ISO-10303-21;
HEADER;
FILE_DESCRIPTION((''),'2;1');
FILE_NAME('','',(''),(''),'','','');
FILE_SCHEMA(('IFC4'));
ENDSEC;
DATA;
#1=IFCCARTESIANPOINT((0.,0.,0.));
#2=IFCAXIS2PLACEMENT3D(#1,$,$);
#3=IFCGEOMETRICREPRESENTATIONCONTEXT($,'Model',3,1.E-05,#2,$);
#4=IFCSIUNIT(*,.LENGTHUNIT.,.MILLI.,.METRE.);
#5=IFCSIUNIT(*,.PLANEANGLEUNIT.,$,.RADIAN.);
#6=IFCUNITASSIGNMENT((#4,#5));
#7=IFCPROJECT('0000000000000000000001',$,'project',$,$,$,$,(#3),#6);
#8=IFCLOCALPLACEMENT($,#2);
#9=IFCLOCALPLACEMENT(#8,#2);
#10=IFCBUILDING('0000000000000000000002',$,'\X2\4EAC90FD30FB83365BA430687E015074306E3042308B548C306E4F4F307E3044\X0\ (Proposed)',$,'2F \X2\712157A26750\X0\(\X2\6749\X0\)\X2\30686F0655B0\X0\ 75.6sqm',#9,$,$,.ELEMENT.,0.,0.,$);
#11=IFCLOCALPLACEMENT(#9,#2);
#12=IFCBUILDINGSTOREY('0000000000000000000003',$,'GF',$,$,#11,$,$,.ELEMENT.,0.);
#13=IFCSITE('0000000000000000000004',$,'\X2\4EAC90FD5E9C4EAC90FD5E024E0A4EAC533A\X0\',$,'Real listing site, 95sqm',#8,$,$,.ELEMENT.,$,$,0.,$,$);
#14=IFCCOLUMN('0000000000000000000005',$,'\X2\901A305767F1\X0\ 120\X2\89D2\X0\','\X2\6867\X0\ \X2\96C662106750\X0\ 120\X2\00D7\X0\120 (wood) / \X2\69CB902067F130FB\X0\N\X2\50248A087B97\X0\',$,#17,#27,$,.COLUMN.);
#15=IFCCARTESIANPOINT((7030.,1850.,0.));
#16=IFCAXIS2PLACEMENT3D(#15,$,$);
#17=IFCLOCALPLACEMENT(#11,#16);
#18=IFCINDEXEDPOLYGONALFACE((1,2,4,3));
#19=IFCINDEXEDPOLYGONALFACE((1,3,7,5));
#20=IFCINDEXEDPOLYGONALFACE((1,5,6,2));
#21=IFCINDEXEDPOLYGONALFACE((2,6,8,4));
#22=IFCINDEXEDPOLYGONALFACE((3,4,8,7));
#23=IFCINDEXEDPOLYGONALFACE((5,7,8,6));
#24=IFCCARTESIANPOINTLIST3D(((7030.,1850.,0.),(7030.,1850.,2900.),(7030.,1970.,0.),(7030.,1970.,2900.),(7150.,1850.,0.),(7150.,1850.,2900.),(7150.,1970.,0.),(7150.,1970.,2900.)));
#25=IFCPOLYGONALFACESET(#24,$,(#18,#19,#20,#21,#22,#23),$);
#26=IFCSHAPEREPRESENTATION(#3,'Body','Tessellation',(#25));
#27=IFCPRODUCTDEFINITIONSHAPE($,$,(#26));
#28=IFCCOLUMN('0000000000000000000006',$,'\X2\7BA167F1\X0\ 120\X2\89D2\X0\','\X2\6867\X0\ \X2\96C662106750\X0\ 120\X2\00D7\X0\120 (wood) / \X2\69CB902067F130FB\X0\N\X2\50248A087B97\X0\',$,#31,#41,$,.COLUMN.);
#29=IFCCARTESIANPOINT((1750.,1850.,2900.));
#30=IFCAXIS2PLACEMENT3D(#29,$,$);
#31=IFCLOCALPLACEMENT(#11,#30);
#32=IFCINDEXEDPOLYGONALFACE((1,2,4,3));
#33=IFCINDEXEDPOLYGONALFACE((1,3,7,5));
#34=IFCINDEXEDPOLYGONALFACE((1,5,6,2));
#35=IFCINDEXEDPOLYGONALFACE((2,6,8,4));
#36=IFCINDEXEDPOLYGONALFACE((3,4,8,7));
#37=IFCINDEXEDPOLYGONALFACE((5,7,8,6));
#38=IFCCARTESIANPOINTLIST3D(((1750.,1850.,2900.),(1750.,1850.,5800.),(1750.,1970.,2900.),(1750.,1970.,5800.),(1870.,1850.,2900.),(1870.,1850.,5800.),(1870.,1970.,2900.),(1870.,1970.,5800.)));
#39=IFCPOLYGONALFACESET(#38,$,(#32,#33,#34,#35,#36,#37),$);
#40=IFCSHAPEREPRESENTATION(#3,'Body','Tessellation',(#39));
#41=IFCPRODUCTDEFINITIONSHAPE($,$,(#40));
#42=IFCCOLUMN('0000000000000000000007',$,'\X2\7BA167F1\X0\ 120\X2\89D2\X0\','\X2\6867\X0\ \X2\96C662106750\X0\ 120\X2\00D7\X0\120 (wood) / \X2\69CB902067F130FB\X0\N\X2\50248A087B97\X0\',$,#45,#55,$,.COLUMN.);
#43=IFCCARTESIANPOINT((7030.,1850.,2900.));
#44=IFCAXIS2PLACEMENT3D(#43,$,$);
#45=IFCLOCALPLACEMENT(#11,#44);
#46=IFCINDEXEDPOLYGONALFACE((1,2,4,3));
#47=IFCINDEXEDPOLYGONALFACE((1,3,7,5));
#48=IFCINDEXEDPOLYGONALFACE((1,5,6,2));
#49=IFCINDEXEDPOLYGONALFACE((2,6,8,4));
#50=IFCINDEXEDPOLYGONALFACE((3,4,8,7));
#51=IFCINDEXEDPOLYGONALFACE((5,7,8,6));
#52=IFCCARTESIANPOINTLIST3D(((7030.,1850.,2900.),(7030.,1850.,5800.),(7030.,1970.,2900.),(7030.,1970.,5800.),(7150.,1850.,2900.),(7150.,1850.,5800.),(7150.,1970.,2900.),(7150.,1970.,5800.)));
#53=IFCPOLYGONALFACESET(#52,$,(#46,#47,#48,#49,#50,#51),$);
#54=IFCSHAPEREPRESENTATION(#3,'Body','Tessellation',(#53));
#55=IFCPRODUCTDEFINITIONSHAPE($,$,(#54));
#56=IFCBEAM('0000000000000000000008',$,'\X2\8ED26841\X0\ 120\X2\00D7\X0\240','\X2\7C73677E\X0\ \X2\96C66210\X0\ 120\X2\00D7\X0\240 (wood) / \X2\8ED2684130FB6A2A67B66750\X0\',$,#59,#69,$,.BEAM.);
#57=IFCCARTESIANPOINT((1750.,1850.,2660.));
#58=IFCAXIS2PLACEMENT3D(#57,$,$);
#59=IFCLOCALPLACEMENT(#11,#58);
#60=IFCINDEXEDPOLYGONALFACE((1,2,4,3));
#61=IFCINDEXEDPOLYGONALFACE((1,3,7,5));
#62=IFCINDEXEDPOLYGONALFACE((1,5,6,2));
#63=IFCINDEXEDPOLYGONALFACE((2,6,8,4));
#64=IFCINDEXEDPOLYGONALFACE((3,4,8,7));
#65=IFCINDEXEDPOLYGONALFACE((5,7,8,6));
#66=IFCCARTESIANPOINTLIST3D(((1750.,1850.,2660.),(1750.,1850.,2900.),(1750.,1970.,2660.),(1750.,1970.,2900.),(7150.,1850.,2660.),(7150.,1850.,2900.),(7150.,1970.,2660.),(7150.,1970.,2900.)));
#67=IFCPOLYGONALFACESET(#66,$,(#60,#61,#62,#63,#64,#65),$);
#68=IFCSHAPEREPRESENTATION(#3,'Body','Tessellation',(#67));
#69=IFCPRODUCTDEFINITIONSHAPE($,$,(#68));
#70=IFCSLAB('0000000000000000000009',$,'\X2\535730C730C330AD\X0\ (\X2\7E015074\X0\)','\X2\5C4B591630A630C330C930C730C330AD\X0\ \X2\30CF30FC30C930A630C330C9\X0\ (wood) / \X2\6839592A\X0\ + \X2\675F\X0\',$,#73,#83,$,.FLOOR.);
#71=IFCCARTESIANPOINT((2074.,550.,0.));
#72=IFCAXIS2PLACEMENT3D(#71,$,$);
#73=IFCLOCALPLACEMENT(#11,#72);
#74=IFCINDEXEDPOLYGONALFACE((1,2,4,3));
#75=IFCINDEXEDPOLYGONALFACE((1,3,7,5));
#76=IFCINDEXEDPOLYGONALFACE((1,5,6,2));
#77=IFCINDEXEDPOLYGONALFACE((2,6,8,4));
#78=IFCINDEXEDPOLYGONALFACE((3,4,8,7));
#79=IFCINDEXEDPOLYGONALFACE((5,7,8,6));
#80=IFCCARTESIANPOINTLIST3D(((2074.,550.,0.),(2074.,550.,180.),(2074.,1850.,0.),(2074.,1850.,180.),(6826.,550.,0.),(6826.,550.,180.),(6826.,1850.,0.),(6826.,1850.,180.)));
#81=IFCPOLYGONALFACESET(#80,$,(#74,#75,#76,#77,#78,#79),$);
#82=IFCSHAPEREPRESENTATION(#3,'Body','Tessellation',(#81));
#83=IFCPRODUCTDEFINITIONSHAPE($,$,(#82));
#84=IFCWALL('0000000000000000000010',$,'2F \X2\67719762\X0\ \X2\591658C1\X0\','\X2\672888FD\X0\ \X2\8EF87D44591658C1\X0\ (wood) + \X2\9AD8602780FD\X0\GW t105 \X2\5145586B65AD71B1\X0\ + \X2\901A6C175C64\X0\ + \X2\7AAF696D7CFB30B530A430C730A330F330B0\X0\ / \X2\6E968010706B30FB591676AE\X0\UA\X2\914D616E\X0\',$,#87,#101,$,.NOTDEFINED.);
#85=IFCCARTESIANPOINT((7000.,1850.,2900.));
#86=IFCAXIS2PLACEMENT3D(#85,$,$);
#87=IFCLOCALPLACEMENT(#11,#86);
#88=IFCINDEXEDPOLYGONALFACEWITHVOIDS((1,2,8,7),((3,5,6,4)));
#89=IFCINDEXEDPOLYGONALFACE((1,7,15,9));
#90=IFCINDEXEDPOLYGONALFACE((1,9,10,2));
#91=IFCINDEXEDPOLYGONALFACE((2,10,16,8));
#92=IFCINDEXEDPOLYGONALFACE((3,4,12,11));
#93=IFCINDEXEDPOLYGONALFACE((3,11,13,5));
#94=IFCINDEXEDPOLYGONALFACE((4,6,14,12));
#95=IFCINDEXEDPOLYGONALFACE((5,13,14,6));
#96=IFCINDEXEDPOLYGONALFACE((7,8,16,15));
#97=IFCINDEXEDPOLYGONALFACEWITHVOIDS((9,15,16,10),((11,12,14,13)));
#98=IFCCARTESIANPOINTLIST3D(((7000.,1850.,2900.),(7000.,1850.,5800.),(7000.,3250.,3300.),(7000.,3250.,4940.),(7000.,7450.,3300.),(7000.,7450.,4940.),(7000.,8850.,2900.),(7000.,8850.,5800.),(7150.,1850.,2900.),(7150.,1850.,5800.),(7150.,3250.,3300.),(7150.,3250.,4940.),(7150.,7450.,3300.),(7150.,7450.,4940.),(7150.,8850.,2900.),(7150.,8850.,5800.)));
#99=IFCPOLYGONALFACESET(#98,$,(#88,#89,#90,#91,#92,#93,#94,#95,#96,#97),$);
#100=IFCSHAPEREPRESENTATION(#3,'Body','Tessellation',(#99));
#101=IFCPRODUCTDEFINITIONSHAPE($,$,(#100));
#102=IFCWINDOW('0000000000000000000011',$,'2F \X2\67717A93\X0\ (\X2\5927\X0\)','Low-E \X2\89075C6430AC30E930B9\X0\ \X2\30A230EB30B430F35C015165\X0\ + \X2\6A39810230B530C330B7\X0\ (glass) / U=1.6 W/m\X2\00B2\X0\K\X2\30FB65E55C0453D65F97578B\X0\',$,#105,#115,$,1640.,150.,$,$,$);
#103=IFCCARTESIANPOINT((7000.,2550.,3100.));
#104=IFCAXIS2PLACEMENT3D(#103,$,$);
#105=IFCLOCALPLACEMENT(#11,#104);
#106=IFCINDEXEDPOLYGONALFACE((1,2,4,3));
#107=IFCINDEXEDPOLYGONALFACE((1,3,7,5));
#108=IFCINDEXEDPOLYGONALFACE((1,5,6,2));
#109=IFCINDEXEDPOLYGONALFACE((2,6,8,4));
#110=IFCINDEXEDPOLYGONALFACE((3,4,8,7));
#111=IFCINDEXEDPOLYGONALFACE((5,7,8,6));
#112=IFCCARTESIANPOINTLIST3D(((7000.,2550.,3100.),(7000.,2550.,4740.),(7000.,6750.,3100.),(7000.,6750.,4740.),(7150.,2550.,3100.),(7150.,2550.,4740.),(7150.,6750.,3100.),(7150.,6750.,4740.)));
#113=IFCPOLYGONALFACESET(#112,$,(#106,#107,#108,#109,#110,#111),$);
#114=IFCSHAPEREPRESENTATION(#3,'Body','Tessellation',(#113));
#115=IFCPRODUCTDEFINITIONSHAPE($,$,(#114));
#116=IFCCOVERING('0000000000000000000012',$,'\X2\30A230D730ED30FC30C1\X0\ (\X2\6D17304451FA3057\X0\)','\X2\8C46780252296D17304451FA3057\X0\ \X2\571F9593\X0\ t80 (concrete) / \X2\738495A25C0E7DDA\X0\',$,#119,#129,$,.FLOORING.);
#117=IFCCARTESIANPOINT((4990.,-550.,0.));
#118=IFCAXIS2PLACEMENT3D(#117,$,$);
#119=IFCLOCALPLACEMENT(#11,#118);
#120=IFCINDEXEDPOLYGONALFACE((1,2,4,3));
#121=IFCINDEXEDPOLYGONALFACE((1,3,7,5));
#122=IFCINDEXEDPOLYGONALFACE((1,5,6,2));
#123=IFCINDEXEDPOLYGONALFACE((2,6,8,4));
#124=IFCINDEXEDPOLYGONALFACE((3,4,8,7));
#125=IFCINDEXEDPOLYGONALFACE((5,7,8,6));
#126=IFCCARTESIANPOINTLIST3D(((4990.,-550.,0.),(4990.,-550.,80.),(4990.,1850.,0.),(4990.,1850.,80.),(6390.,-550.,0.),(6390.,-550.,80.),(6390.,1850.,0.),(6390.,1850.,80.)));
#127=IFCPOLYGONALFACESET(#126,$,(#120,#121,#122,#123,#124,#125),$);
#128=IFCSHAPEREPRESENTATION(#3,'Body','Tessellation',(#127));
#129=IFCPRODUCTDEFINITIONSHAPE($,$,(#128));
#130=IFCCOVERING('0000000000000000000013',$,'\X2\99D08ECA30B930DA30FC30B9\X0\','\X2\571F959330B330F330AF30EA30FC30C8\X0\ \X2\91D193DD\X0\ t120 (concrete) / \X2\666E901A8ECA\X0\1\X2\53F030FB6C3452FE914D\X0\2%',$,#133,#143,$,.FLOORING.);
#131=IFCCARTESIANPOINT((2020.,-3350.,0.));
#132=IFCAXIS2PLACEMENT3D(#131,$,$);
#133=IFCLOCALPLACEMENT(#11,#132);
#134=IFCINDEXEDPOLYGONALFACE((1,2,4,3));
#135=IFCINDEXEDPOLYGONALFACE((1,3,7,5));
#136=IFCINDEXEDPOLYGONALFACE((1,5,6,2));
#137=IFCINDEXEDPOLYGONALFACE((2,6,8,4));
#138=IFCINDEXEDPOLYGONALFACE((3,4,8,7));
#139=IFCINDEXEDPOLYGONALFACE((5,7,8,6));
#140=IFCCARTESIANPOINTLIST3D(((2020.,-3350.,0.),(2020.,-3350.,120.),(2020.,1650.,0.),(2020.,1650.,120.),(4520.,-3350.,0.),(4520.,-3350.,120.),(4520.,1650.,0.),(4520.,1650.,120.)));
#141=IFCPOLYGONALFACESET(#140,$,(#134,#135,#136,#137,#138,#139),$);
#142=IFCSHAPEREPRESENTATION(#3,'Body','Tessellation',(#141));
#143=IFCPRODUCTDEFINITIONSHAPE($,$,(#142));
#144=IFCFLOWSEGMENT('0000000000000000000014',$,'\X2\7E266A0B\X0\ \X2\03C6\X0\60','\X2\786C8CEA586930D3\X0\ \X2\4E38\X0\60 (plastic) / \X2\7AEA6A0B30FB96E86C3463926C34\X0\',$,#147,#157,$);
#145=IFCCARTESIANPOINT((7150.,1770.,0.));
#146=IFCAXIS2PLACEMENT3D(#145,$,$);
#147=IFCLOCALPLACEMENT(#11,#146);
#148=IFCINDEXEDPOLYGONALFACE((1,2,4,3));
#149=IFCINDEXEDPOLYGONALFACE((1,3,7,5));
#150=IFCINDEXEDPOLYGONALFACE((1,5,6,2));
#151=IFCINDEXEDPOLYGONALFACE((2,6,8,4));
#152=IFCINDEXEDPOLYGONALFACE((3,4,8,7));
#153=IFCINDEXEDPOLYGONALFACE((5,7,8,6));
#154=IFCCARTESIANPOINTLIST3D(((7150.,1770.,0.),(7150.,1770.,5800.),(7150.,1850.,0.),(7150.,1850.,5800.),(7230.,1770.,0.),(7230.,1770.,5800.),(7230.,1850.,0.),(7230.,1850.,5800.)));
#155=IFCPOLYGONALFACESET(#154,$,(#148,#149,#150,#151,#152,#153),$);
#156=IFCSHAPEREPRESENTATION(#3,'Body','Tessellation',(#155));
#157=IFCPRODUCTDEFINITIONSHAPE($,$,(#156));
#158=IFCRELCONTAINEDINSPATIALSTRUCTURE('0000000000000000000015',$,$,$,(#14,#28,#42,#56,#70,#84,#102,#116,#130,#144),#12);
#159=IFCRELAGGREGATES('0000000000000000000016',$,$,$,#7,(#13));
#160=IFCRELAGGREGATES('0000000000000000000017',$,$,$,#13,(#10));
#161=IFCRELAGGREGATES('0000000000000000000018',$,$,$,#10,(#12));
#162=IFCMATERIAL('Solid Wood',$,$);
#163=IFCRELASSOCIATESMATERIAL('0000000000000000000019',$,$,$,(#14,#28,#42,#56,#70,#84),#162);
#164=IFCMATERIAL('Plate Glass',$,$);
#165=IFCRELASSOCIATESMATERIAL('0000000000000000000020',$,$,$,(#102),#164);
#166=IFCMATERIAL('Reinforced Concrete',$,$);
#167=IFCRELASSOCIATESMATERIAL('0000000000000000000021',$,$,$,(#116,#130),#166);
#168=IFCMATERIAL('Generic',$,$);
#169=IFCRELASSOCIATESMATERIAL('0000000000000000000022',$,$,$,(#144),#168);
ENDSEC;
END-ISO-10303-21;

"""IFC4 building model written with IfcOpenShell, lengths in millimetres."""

from ifc_helpers import new_model, si_unit, frame, frame_2d, origin, place, context, project, spatial, rectangle, extrude, material, element, fill, save


model = new_model("IFC4")

# Units and contexts
model_context = context("Model", 3, precision=1e-05, world=origin())
ifc_project = project(units=[si_unit("LENGTHUNIT", "METRE", prefix="MILLI"), si_unit("PLANEANGLEUNIT", "RADIAN")], contexts=[model_context])

# Site, building, storey
site_placement = place(None, origin())
site = spatial("IfcSite", under=ifc_project, at=site_placement, Name="京都府京都市上京区", ObjectType="Real listing site, 95sqm", CompositionType="ELEMENT", RefElevation=0.0)
building_placement = place(site_placement, origin())
building = spatial("IfcBuilding", under=site, at=building_placement, Name="京都・茶室と縁側のある和の住まい (Proposed)", ObjectType="2F 無垢材(杉)と漆喰 75.6sqm", CompositionType="ELEMENT", ElevationOfRefHeight=0.0, ElevationOfTerrain=0.0)
storey_placement = place(building_placement, origin())
storey = spatial("IfcBuildingStorey", under=building, at=storey_placement, Name="GF", CompositionType="ELEMENT", Elevation=0.0)

# Columns
ifc_material_1 = material(Name="Solid Wood")
column_1_placement = place(storey_placement, frame((7030.0, 1850.0, 0.0)))
element("IfcColumn", 1, at=column_1_placement, inside=storey, material=ifc_material_1, Name="通し柱 120角", Description="桧 集成材 120×120 (wood) / 構造柱・N値計算", PredefinedType="COLUMN", context=model_context, shape_type="SweptSolid", body=[
    extrude(rectangle(XDim=120.0, YDim=120.0, at=frame_2d((60.0, 60.0))), frame((7030.0, 1850.0, 0.0)), (0.0, 0.0, 1.0), 2900.0),
])
column_2_placement = place(storey_placement, frame((1750.0, 1850.0, 2900.0)))
element("IfcColumn", 2, at=column_2_placement, inside=storey, material=ifc_material_1, Name="管柱 120角", Description="桧 集成材 120×120 (wood) / 構造柱・N値計算", PredefinedType="COLUMN", context=model_context, shape_type="SweptSolid", body=[
    extrude(rectangle(XDim=120.0, YDim=120.0, at=frame_2d((60.0, 60.0))), frame((1750.0, 1850.0, 2900.0)), (0.0, 0.0, 1.0), 2900.0),
])
column_3_placement = place(storey_placement, frame((7030.0, 1850.0, 2900.0)))
element("IfcColumn", 3, at=column_3_placement, inside=storey, material=ifc_material_1, Name="管柱 120角", Description="桧 集成材 120×120 (wood) / 構造柱・N値計算", PredefinedType="COLUMN", context=model_context, shape_type="SweptSolid", body=[
    extrude(rectangle(XDim=120.0, YDim=120.0, at=frame_2d((60.0, 60.0))), frame((7030.0, 1850.0, 2900.0)), (0.0, 0.0, 1.0), 2900.0),
])

# Beam
beam_1_placement = place(storey_placement, frame((1750.0, 1850.0, 2660.0)))
element("IfcBeam", 4, at=beam_1_placement, inside=storey, material=ifc_material_1, Name="軒桁 120×240", Description="米松 集成 120×240 (wood) / 軒桁・横架材", PredefinedType="BEAM", context=model_context, shape_type="SweptSolid", body=[
    extrude(rectangle(XDim=5400.0, YDim=120.0, at=frame_2d((2700.0, 60.0))), frame((1750.0, 1850.0, 2660.0)), (0.0, 0.0, 1.0), 240.0),
])

# Slab
slab_placement = place(storey_placement, frame((2074.0, 550.0, 0.0)))
element("IfcSlab", 5, at=slab_placement, inside=storey, material=ifc_material_1, Name="南デッキ (縁側)", Description="屋外ウッドデッキ ハードウッド (wood) / 根太 + 束", PredefinedType="FLOOR", context=model_context, shape_type="SweptSolid", body=[
    extrude(rectangle(XDim=4752.0, YDim=1300.0, at=frame_2d((2376.0, 650.0))), frame((2074.0, 550.0, 0.0)), (0.0, 0.0, 1.0), 180.0),
])

# Wall, opening, window
ifc_material_2 = material(Name="Plate Glass")
wall_1_placement = place(storey_placement, frame((7000.0, 1850.0, 2900.0)))
wall_1 = element("IfcWall", 6, at=wall_1_placement, inside=storey, material=ifc_material_1, Name="2F 東面 外壁", Description="木製 軸組外壁 (wood) + 高性能GW t105 充填断熱 + 通気層 + 窯業系サイディング / 準耐火・外皮UA配慮", PredefinedType="NOTDEFINED", context=model_context, shape_type="SweptSolid", body=[
    extrude(rectangle(XDim=150.0, YDim=7000.0, at=frame_2d((75.0, 3500.0))), frame((7000.0, 1850.0, 2900.0)), (0.0, 0.0, 1.0), 2900.0),
])
opening_1_placement = place(storey_placement, frame((7000.0, 2550.0, 3100.0)))
opening_1 = element("IfcOpeningElement", 7, at=opening_1_placement, cuts=wall_1, PredefinedType="NOTDEFINED", context=model_context, shape_type="SweptSolid", body=[
    extrude(rectangle(XDim=150.0, YDim=4200.0, at=frame_2d((75.0, 2100.0))), frame((7000.0, 2550.0, 3100.0)), (0.0, 0.0, 1.0), 1640.0),
])
window_1_placement = place(storey_placement, frame((7000.0, 2550.0, 3100.0)))
window_1 = element("IfcWindow", 8, at=window_1_placement, inside=storey, material=ifc_material_2, Name="2F 東窓 (大)", Description="Low-E 複層ガラス アルゴン封入 + 樹脂サッシ (glass) / U=1.6 W/m²K・日射取得型", OverallHeight=1640.0, OverallWidth=150.0, context=model_context, shape_type="SweptSolid", body=[
    extrude(rectangle(XDim=150.0, YDim=4200.0, at=frame_2d((75.0, 2100.0))), frame((7000.0, 2550.0, 3100.0)), (0.0, 0.0, 1.0), 1640.0),
])
fill(opening_1, window_1)

# Coverings
ifc_material_3 = material(Name="Reinforced Concrete")
covering_1_placement = place(storey_placement, frame((4990.0, -550.0, 0.0)))
element("IfcCovering", 9, at=covering_1_placement, inside=storey, material=ifc_material_3, Name="アプローチ (洗い出し)", Description="豆砂利洗い出し 土間 t80 (concrete) / 玄関導線", PredefinedType="FLOORING", context=model_context, shape_type="SweptSolid", body=[
    extrude(rectangle(XDim=1400.0, YDim=2400.0, at=frame_2d((700.0, 1200.0))), frame((4990.0, -550.0, 0.0)), (0.0, 0.0, 1.0), 80.0),
])
covering_2_placement = place(storey_placement, frame((2020.0, -3350.0, 0.0)))
element("IfcCovering", 10, at=covering_2_placement, inside=storey, material=ifc_material_3, Name="駐車スペース", Description="土間コンクリート 金鏝 t120 (concrete) / 普通車1台・水勾配2%", PredefinedType="FLOORING", context=model_context, shape_type="SweptSolid", body=[
    extrude(rectangle(XDim=2500.0, YDim=5000.0, at=frame_2d((1250.0, 2500.0))), frame((2020.0, -3350.0, 0.0)), (0.0, 0.0, 1.0), 120.0),
])

# Flow segment
ifc_material_4 = material(Name="Generic")
flow_segment_placement = place(storey_placement, frame((7150.0, 1770.0, 0.0)))
element("IfcFlowSegment", 11, at=flow_segment_placement, inside=storey, material=ifc_material_4, Name="縦樋 φ60", Description="硬質塩ビ 丸60 (plastic) / 竪樋・雨水排水", context=model_context, shape_type="SweptSolid", body=[
    extrude(rectangle(XDim=80.0, YDim=80.0, at=frame_2d((40.0, 40.0))), frame((7150.0, 1770.0, 0.0)), (0.0, 0.0, 1.0), 5800.0),
])

save(model, "model.ifc")
